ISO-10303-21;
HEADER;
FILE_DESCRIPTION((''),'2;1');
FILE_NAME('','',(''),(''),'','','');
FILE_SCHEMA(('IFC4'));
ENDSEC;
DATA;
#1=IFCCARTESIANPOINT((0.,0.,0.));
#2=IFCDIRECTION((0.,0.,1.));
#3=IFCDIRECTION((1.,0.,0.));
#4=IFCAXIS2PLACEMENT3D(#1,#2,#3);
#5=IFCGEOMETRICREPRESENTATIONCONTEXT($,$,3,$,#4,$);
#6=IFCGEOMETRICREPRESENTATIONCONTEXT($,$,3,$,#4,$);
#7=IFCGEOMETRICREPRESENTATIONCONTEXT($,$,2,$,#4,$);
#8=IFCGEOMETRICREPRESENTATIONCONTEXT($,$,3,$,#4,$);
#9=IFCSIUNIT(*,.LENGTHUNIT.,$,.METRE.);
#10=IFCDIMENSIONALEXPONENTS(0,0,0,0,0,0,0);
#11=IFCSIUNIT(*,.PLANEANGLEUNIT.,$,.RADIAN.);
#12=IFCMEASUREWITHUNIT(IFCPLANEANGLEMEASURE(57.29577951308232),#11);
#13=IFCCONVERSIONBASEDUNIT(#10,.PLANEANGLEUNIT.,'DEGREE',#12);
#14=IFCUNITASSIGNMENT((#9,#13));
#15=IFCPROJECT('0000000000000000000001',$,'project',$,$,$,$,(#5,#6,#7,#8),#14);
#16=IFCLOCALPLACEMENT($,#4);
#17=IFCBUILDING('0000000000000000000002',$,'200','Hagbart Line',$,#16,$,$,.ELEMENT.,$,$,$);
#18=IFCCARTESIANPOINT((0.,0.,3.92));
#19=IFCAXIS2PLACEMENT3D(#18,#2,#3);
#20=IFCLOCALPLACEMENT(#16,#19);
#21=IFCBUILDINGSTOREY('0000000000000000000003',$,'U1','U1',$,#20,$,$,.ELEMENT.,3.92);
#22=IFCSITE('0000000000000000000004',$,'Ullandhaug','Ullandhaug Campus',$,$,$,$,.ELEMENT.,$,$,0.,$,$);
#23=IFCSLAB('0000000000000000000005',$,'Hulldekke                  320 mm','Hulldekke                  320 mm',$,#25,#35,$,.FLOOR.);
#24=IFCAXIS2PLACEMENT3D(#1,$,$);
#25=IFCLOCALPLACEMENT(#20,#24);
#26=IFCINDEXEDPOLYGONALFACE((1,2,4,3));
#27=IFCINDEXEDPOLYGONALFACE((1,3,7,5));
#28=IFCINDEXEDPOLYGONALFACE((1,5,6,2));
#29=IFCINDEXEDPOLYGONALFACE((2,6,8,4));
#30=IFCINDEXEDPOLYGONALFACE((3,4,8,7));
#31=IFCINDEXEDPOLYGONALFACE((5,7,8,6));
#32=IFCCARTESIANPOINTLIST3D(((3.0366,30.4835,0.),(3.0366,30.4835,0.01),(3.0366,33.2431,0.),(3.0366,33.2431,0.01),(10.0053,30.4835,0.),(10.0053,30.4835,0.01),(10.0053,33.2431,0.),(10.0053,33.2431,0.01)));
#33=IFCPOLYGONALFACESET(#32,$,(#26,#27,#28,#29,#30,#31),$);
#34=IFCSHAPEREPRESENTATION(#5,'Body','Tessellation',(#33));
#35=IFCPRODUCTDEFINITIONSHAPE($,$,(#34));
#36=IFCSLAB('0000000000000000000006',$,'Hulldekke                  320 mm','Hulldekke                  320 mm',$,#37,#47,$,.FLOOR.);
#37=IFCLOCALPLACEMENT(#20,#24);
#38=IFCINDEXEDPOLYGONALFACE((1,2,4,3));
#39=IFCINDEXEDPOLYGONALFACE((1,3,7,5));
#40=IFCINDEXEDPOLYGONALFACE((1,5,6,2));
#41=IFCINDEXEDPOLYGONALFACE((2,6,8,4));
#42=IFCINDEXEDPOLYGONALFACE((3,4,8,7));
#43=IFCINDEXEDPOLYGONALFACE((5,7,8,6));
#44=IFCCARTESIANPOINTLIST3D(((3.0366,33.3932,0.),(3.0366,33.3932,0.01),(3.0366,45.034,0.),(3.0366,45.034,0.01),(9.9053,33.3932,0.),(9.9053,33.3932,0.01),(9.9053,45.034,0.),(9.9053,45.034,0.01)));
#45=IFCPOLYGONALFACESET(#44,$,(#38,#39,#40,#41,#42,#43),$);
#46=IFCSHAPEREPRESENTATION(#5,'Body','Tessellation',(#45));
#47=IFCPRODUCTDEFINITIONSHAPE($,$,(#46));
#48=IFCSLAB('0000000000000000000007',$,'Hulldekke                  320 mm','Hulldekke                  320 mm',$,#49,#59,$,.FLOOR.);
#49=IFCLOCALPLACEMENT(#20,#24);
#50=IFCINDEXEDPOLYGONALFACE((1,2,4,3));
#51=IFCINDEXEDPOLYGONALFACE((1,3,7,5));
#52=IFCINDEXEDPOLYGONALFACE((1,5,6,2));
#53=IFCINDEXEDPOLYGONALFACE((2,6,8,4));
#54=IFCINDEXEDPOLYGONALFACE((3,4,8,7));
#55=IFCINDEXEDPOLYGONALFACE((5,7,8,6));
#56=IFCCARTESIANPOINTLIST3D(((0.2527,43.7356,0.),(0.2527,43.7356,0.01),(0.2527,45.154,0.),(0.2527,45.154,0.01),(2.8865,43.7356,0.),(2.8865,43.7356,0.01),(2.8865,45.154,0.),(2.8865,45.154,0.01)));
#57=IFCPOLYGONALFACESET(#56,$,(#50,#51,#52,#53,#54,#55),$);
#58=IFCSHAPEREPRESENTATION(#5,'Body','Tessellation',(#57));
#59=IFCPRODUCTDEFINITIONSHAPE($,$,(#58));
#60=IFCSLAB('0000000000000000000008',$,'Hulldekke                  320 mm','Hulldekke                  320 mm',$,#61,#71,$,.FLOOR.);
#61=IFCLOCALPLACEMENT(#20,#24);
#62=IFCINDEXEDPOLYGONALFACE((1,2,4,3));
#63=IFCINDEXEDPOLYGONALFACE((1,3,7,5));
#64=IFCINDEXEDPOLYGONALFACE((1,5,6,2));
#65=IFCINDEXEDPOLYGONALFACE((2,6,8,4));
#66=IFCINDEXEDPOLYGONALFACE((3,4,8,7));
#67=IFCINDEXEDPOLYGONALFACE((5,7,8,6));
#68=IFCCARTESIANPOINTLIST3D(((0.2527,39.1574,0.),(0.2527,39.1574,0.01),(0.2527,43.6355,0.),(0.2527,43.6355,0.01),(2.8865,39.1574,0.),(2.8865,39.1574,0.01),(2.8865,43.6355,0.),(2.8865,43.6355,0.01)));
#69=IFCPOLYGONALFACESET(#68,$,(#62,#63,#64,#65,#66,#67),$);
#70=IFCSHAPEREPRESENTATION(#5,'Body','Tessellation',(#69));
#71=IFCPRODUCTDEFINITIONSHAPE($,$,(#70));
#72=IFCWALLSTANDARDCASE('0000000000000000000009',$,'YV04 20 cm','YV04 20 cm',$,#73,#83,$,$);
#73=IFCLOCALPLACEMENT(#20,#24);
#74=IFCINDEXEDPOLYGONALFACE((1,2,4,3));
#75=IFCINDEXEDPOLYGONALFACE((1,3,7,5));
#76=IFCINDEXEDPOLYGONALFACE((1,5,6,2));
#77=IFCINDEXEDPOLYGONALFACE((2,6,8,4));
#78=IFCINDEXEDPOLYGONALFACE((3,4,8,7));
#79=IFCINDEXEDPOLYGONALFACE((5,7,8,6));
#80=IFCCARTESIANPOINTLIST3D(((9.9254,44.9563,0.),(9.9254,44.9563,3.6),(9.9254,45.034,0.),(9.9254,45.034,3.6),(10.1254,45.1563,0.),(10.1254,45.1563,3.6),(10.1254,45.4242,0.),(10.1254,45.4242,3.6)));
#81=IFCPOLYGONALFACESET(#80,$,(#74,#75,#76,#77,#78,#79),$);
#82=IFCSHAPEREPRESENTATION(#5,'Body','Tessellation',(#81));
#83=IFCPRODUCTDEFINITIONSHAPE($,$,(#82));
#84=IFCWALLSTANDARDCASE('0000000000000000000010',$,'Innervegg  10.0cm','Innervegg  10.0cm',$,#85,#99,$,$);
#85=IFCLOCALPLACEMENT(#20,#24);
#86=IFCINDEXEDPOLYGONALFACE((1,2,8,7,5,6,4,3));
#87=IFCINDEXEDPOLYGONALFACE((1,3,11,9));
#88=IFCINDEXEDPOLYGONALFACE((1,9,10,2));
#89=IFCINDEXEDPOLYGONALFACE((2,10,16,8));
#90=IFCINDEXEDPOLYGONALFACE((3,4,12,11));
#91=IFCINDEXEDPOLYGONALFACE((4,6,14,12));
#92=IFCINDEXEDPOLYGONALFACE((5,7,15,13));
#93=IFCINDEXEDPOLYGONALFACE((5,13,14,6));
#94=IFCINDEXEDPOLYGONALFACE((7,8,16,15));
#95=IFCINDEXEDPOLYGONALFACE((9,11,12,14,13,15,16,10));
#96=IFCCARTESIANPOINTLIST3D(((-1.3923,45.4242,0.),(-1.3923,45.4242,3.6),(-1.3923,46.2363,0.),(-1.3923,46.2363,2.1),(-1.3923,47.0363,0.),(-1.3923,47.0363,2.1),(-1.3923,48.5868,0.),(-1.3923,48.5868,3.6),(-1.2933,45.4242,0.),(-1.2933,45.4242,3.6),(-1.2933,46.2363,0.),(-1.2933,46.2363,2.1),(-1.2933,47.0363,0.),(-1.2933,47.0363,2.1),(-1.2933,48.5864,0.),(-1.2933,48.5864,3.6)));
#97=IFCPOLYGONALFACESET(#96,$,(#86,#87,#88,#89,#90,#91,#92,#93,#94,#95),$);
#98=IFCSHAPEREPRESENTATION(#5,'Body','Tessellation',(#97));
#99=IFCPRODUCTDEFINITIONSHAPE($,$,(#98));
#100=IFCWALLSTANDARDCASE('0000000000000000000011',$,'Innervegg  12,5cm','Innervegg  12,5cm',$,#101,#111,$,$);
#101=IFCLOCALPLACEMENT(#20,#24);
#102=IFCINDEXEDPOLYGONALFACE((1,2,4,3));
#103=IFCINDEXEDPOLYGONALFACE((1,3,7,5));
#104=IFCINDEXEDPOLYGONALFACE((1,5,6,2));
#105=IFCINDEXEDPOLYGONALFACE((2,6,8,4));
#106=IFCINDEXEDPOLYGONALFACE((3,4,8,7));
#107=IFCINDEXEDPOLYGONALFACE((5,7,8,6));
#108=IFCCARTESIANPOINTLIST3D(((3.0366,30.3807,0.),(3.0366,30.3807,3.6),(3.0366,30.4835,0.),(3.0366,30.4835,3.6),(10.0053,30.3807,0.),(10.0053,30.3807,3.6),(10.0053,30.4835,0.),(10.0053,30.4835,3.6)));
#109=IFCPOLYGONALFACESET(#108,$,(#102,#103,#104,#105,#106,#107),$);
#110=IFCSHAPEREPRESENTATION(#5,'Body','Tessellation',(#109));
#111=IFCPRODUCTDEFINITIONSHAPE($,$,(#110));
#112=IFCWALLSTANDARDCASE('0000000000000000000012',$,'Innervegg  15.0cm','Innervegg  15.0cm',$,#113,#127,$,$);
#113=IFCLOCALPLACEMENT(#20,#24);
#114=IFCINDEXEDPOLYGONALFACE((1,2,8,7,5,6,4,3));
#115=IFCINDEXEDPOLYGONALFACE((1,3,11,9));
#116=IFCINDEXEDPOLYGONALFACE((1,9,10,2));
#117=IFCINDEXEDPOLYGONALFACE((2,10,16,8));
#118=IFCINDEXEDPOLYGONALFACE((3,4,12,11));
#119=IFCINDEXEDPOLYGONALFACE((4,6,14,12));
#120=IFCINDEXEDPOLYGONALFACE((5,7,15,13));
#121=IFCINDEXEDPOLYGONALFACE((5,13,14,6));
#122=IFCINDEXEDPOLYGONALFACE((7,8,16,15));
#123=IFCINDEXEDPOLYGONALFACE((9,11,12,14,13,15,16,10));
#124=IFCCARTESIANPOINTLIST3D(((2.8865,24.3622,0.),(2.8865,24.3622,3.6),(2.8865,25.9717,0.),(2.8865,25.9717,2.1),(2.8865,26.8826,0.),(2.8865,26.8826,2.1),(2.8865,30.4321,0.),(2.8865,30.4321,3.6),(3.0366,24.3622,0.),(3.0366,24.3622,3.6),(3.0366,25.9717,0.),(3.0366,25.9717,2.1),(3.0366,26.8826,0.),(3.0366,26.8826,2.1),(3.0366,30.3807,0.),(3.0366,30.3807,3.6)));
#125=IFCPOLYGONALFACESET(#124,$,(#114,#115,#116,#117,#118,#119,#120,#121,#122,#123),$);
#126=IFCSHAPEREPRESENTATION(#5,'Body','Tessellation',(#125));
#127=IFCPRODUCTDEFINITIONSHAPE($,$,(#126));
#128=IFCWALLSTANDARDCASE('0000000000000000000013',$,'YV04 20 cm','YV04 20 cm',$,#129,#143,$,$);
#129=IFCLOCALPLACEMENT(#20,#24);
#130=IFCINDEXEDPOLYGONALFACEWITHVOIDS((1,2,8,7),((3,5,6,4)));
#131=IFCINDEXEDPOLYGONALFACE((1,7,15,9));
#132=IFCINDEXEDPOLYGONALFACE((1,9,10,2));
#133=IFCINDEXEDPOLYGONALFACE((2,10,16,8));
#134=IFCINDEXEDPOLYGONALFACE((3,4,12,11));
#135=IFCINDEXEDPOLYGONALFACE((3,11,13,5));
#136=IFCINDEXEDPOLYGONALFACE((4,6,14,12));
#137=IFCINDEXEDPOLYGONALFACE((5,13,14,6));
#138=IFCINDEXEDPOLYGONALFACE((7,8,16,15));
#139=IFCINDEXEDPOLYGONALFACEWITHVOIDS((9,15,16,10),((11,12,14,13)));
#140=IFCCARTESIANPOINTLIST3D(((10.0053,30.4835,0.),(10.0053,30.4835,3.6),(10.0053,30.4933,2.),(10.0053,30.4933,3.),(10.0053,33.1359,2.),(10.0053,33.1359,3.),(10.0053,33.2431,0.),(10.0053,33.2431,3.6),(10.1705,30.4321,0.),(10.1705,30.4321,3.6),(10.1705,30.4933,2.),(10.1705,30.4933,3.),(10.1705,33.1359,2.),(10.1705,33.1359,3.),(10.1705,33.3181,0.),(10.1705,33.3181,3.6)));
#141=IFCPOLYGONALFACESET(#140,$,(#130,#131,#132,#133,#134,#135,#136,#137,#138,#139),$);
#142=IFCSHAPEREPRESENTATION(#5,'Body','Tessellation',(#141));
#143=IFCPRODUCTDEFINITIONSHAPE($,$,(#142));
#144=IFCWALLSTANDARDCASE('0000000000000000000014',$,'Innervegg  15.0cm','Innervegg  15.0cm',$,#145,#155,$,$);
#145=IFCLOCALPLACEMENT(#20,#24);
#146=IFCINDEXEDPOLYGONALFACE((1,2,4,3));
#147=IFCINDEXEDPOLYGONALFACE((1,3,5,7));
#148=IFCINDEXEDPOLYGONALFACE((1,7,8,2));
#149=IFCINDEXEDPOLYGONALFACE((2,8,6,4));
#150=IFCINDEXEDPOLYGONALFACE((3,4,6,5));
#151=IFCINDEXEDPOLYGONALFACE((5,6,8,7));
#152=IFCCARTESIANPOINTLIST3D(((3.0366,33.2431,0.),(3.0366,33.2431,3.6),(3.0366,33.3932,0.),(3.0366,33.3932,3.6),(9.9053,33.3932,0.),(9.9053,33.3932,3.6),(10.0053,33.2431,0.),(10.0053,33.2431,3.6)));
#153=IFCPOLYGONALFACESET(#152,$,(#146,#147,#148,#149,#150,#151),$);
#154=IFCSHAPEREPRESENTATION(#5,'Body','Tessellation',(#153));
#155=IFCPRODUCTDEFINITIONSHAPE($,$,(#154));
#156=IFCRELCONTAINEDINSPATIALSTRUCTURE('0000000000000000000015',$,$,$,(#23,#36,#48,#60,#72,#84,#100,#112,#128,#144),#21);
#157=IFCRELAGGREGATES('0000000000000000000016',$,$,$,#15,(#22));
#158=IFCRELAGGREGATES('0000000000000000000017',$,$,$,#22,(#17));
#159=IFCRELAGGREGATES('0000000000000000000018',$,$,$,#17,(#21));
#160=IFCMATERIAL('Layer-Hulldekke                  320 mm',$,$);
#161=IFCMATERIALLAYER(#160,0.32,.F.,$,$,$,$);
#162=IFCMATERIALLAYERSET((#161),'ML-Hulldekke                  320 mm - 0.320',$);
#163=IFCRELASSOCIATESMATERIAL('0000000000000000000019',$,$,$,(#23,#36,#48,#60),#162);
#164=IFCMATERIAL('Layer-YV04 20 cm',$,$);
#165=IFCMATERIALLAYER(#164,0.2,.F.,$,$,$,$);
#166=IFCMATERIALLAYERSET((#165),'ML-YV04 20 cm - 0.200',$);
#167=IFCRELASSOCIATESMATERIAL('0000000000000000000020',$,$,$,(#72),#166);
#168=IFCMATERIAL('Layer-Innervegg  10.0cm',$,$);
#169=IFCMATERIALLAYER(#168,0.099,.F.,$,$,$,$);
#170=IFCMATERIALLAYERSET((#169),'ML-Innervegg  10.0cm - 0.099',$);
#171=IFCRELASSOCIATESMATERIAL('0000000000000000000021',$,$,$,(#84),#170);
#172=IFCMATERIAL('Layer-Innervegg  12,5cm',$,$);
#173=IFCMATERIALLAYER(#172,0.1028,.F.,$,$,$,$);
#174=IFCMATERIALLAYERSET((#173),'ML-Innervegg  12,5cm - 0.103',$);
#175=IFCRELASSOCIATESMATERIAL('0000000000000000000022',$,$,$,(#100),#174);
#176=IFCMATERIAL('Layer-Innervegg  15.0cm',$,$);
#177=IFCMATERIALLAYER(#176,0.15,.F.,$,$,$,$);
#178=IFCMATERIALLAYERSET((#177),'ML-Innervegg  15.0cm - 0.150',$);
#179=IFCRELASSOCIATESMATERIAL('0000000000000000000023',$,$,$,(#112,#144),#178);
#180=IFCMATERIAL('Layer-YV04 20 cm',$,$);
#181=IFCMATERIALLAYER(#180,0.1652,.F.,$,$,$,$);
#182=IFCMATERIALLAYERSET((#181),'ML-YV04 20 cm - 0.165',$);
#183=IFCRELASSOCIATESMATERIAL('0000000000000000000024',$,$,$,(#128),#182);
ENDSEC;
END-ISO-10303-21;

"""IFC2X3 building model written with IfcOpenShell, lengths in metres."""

from ifc_helpers import new_model, entity, si_unit, converted_unit, frame, origin_with_axes, place, context, project, spatial, polyline, outline, extrude, material, layer, layer_set, layer_usage, element, save


model = new_model("IFC2X3")

# Units and contexts
context_of_model_1 = context(None, 3, world=origin_with_axes())
context_of_model_2 = context(None, 3, world=origin_with_axes())
context_of_model_3 = context(None, 2, world=origin_with_axes())
context_of_model_4 = context(None, 3, world=origin_with_axes())
ifc_project = project(units=[si_unit("LENGTHUNIT", "METRE"), converted_unit("PLANEANGLEUNIT", "DEGREE", entity("IfcPlaneAngleMeasure", 57.29577951308232), si_unit("PLANEANGLEUNIT", "RADIAN"), dimensions=[0, 0, 0, 0, 0, 0, 0])], contexts=[context_of_model_1, context_of_model_2, context_of_model_3, context_of_model_4])

# Site, building, storey
site = spatial("IfcSite", under=ifc_project, Name="Ullandhaug", Description="Ullandhaug Campus", CompositionType="ELEMENT", RefElevation=0.0)
building_placement = place(None, origin_with_axes())
building = spatial("IfcBuilding", under=site, at=building_placement, Name="200", Description="Hagbart Line", CompositionType="ELEMENT")
storey_placement = place(building_placement, frame((0.0, 0.0, 3.92), z_axis=(0.0, 0.0, 1.0), x_axis=(1.0, 0.0, 0.0)))
storey = spatial("IfcBuildingStorey", under=building, at=storey_placement, Name="U1", Description="U1", CompositionType="ELEMENT", Elevation=3.92)

# Slabs
ifc_material_1 = material(Name="Layer-Hulldekke                  320 mm")
ifc_layer_1 = layer(ifc_material_1, 0.32, ventilated=False)
ifc_layer_set_1 = layer_set([ifc_layer_1], Name="ML-Hulldekke                  320 mm - 0.320")
ifc_layer_usage_1 = layer_usage(ifc_layer_set_1, "AXIS2", "POSITIVE", 0.0)
slab_1_placement = place(storey_placement, frame((3.0366, 30.4835, 0.0), z_axis=(0.0, 0.0, 1.0), x_axis=(1.0, 0.0, 0.0)))
element("IfcSlab", 1, at=slab_1_placement, inside=storey, material=ifc_layer_usage_1, Name="Hulldekke                  320 mm", Description="Hulldekke                  320 mm", PredefinedType="FLOOR", context=context_of_model_1, shape_type="SweptSolid", body=[
    extrude(outline(polyline([(0.0, 0.0), (6.9687, 0.0), (6.9687, 2.7596), (0.0, 2.7596), (0.0, 0.0)])), origin_with_axes(), (0.0, 0.0, 1.0), 0.01),
])
slab_2_placement = place(storey_placement, frame((3.0366, 33.3932, 0.0), z_axis=(0.0, 0.0, 1.0), x_axis=(1.0, 0.0, 0.0)))
element("IfcSlab", 2, at=slab_2_placement, inside=storey, material=ifc_layer_usage_1, Name="Hulldekke                  320 mm", Description="Hulldekke                  320 mm", PredefinedType="FLOOR", context=context_of_model_1, shape_type="SweptSolid", body=[
    extrude(outline(polyline([(0.0, 0.0), (6.8687, 0.0), (6.8687, 11.6407), (0.0, 11.6407), (0.0, 0.0)])), origin_with_axes(), (0.0, 0.0, 1.0), 0.01),
])
slab_3_placement = place(storey_placement, frame((0.2527, 43.7356, 0.0), z_axis=(0.0, 0.0, 1.0), x_axis=(1.0, 0.0, 0.0)))
element("IfcSlab", 3, at=slab_3_placement, inside=storey, material=ifc_layer_usage_1, Name="Hulldekke                  320 mm", Description="Hulldekke                  320 mm", PredefinedType="FLOOR", context=context_of_model_1, shape_type="SweptSolid", body=[
    extrude(outline(polyline([(0.0, 0.0), (2.6338, 0.0), (2.6338, 1.4184), (0.0, 1.4184), (0.0, 0.0)])), origin_with_axes(), (0.0, 0.0, 1.0), 0.01),
])
slab_4_placement = place(storey_placement, frame((0.2527, 39.1574, 0.0), z_axis=(0.0, 0.0, 1.0), x_axis=(1.0, 0.0, 0.0)))
element("IfcSlab", 4, at=slab_4_placement, inside=storey, material=ifc_layer_usage_1, Name="Hulldekke                  320 mm", Description="Hulldekke                  320 mm", PredefinedType="FLOOR", context=context_of_model_1, shape_type="SweptSolid", body=[
    extrude(outline(polyline([(0.0, 0.0), (2.6338, 0.0), (2.6338, 4.4781), (0.0, 4.4781), (0.0, 0.0)])), origin_with_axes(), (0.0, 0.0, 1.0), 0.01),
])

# Wall
ifc_material_2 = material(Name="Layer-YV04 20 cm")
ifc_layer_2 = layer(ifc_material_2, 0.2, ventilated=False)
ifc_layer_set_2 = layer_set([ifc_layer_2], Name="ML-YV04 20 cm - 0.200")
ifc_layer_usage_2 = layer_usage(ifc_layer_set_2, "AXIS2", "POSITIVE", 0.0)
wall_1_placement = place(storey_placement, frame((10.1254, 45.1563, 0.0), z_axis=(0.0, 0.0, 1.0), x_axis=(0.0, 1.0, 0.0)))
element("IfcWallStandardCase", 5, at=wall_1_placement, inside=storey, material=ifc_layer_usage_2, Name="YV04 20 cm", Description="YV04 20 cm", context=context_of_model_1, shape_type="SweptSolid", body=[
    extrude(outline(polyline([(0.0, 0.0), (0.2679, 0.0), (-0.1224, 0.2), (-0.2, 0.2), (0.0, 0.0)])), frame((0.0, 0.0, 0.0), z_axis=(0.0, 0.0, 1.0), x_axis=(1.0, 0.0, 0.0)), (0.0, 0.0, 1.0), 3.6),
])

# Wall, opening
ifc_material_3 = material(Name="Layer-Innervegg  10.0cm")
ifc_layer_3 = layer(ifc_material_3, 0.099, ventilated=False)
ifc_layer_set_3 = layer_set([ifc_layer_3], Name="ML-Innervegg  10.0cm - 0.099")
ifc_layer_usage_3 = layer_usage(ifc_layer_set_3, "AXIS2", "POSITIVE", 0.0)
wall_2_placement = place(storey_placement, frame((-1.2933, 45.4242, 0.0), z_axis=(0.0, 0.0, 1.0), x_axis=(0.0, 1.0, 0.0)))
wall_2 = element("IfcWallStandardCase", 6, at=wall_2_placement, inside=storey, material=ifc_layer_usage_3, Name="Innervegg  10.0cm", Description="Innervegg  10.0cm", context=context_of_model_1, shape_type="SweptSolid", body=[
    extrude(outline(polyline([(0.0, 0.0), (3.1622, 0.0), (3.1626, 0.099), (0.0, 0.099), (0.0, 0.0)])), frame((0.0, 0.0, 0.0), z_axis=(0.0, 0.0, 1.0), x_axis=(1.0, 0.0, 0.0)), (0.0, 0.0, 1.0), 3.6),
])
opening_1_placement = place(wall_2_placement, frame((0.812, 0.099, 0.0), z_axis=(0.0, 0.0, 1.0), x_axis=(1.0, 0.0, 0.0)))
element("IfcOpeningElement", 7, at=opening_1_placement, cuts=wall_2, context=context_of_model_1, shape_type="SweptSolid", body=[
    extrude(outline(polyline([(0.0, 0.0), (2.1, 0.0), (2.1, 0.8), (0.0, 0.8), (0.0, 0.0)])), frame((0.0, 0.0, 0.0), z_axis=(0.0, 1.0, 0.0), x_axis=(0.0, 0.0, 1.0)), (0.0, 0.0, -1.0), 0.099),
])

# Wall
ifc_material_4 = material(Name="Layer-Innervegg  12,5cm")
ifc_layer_4 = layer(ifc_material_4, 0.1028, ventilated=False)
ifc_layer_set_4 = layer_set([ifc_layer_4], Name="ML-Innervegg  12,5cm - 0.103")
ifc_layer_usage_4 = layer_usage(ifc_layer_set_4, "AXIS2", "POSITIVE", 0.0)
wall_3_placement = place(storey_placement, frame((10.0053, 30.4835, 0.0), z_axis=(0.0, 0.0, 1.0), x_axis=(-1.0, 0.0, 0.0)))
element("IfcWallStandardCase", 8, at=wall_3_placement, inside=storey, material=ifc_layer_usage_4, Name="Innervegg  12,5cm", Description="Innervegg  12,5cm", context=context_of_model_1, shape_type="SweptSolid", body=[
    extrude(outline(polyline([(0.0, 0.0), (6.9687, 0.0), (6.9687, 0.1028), (0.0, 0.1028), (0.0, 0.0)])), frame((0.0, 0.0, 0.0), z_axis=(0.0, 0.0, 1.0), x_axis=(1.0, 0.0, 0.0)), (0.0, 0.0, 1.0), 3.6),
])

# Walls, openings
ifc_material_5 = material(Name="Layer-Innervegg  15.0cm")
ifc_layer_5 = layer(ifc_material_5, 0.15, ventilated=False)
ifc_layer_set_5 = layer_set([ifc_layer_5], Name="ML-Innervegg  15.0cm - 0.150")
ifc_layer_usage_5 = layer_usage(ifc_layer_set_5, "AXIS2", "POSITIVE", 0.0)
wall_4_placement = place(storey_placement, frame((2.8865, 30.4321, 0.0), z_axis=(0.0, 0.0, 1.0), x_axis=(0.0, -1.0, 0.0)))
wall_4 = element("IfcWallStandardCase", 9, at=wall_4_placement, inside=storey, material=ifc_layer_usage_5, Name="Innervegg  15.0cm", Description="Innervegg  15.0cm", context=context_of_model_1, shape_type="SweptSolid", body=[
    extrude(outline(polyline([(0.0, 0.0), (6.0698, 0.0), (6.0698, 0.1502), (0.0514, 0.1502), (0.0, 0.0)])), frame((0.0, 0.0, 0.0), z_axis=(0.0, 0.0, 1.0), x_axis=(1.0, 0.0, 0.0)), (0.0, 0.0, 1.0), 3.6),
])
opening_2_placement = place(wall_4_placement, frame((3.5495, 0.1502, 0.0), z_axis=(0.0, 0.0, 1.0), x_axis=(1.0, 0.0, 0.0)))
element("IfcOpeningElement", 10, at=opening_2_placement, cuts=wall_4, context=context_of_model_1, shape_type="SweptSolid", body=[
    extrude(outline(polyline([(0.0, 0.0), (2.1, 0.0), (2.1, 0.9109), (0.0, 0.9109), (0.0, 0.0)])), frame((0.0, 0.0, 0.0), z_axis=(0.0, 1.0, 0.0), x_axis=(0.0, 0.0, 1.0)), (0.0, 0.0, -1.0), 0.1502),
])
ifc_material_6 = material(Name="Layer-YV04 20 cm")
ifc_layer_6 = layer(ifc_material_6, 0.1652, ventilated=False)
ifc_layer_set_6 = layer_set([ifc_layer_6], Name="ML-YV04 20 cm - 0.165")
ifc_layer_usage_6 = layer_usage(ifc_layer_set_6, "AXIS2", "POSITIVE", 0.0)
wall_5_placement = place(storey_placement, frame((10.1705, 30.4321, 0.0), z_axis=(0.0, 0.0, 1.0), x_axis=(0.0, 1.0, 0.0)))
wall_5 = element("IfcWallStandardCase", 11, at=wall_5_placement, inside=storey, material=ifc_layer_usage_6, Name="YV04 20 cm", Description="YV04 20 cm", context=context_of_model_1, shape_type="SweptSolid", body=[
    extrude(outline(polyline([(0.0, 0.0), (2.8861, 0.0), (2.811, 0.1652), (0.0514, 0.1652), (0.0, 0.0)])), frame((0.0, 0.0, 0.0), z_axis=(0.0, 0.0, 1.0), x_axis=(1.0, 0.0, 0.0)), (0.0, 0.0, 1.0), 3.6),
])
opening_3_placement = place(wall_5_placement, frame((0.0612, 0.1652, 2.0), z_axis=(0.0, 0.0, 1.0), x_axis=(1.0, 0.0, 0.0)))
element("IfcOpeningElement", 12, at=opening_3_placement, cuts=wall_5, context=context_of_model_1, shape_type="SweptSolid", body=[
    extrude(outline(polyline([(0.0, 0.0), (1.0, 0.0), (1.0, 2.6426), (0.0, 2.6426), (0.0, 0.0)])), frame((0.0, 0.0, 0.0), z_axis=(0.0, 1.0, 0.0), x_axis=(0.0, 0.0, 1.0)), (0.0, 0.0, -1.0), 0.1652),
])

# Wall
wall_6_placement = place(storey_placement, frame((9.9053, 33.3932, 0.0), z_axis=(0.0, 0.0, 1.0), x_axis=(-1.0, 0.0, 0.0)))
element("IfcWallStandardCase", 13, at=wall_6_placement, inside=storey, material=ifc_layer_usage_5, Name="Innervegg  15.0cm", Description="Innervegg  15.0cm", context=context_of_model_1, shape_type="SweptSolid", body=[
    extrude(outline(polyline([(0.0, 0.0), (6.8687, 0.0), (6.8687, 0.1502), (-0.1, 0.1502), (0.0, 0.0)])), frame((0.0, 0.0, 0.0), z_axis=(0.0, 0.0, 1.0), x_axis=(1.0, 0.0, 0.0)), (0.0, 0.0, 1.0), 3.6),
])

save(model, "model.ifc")
